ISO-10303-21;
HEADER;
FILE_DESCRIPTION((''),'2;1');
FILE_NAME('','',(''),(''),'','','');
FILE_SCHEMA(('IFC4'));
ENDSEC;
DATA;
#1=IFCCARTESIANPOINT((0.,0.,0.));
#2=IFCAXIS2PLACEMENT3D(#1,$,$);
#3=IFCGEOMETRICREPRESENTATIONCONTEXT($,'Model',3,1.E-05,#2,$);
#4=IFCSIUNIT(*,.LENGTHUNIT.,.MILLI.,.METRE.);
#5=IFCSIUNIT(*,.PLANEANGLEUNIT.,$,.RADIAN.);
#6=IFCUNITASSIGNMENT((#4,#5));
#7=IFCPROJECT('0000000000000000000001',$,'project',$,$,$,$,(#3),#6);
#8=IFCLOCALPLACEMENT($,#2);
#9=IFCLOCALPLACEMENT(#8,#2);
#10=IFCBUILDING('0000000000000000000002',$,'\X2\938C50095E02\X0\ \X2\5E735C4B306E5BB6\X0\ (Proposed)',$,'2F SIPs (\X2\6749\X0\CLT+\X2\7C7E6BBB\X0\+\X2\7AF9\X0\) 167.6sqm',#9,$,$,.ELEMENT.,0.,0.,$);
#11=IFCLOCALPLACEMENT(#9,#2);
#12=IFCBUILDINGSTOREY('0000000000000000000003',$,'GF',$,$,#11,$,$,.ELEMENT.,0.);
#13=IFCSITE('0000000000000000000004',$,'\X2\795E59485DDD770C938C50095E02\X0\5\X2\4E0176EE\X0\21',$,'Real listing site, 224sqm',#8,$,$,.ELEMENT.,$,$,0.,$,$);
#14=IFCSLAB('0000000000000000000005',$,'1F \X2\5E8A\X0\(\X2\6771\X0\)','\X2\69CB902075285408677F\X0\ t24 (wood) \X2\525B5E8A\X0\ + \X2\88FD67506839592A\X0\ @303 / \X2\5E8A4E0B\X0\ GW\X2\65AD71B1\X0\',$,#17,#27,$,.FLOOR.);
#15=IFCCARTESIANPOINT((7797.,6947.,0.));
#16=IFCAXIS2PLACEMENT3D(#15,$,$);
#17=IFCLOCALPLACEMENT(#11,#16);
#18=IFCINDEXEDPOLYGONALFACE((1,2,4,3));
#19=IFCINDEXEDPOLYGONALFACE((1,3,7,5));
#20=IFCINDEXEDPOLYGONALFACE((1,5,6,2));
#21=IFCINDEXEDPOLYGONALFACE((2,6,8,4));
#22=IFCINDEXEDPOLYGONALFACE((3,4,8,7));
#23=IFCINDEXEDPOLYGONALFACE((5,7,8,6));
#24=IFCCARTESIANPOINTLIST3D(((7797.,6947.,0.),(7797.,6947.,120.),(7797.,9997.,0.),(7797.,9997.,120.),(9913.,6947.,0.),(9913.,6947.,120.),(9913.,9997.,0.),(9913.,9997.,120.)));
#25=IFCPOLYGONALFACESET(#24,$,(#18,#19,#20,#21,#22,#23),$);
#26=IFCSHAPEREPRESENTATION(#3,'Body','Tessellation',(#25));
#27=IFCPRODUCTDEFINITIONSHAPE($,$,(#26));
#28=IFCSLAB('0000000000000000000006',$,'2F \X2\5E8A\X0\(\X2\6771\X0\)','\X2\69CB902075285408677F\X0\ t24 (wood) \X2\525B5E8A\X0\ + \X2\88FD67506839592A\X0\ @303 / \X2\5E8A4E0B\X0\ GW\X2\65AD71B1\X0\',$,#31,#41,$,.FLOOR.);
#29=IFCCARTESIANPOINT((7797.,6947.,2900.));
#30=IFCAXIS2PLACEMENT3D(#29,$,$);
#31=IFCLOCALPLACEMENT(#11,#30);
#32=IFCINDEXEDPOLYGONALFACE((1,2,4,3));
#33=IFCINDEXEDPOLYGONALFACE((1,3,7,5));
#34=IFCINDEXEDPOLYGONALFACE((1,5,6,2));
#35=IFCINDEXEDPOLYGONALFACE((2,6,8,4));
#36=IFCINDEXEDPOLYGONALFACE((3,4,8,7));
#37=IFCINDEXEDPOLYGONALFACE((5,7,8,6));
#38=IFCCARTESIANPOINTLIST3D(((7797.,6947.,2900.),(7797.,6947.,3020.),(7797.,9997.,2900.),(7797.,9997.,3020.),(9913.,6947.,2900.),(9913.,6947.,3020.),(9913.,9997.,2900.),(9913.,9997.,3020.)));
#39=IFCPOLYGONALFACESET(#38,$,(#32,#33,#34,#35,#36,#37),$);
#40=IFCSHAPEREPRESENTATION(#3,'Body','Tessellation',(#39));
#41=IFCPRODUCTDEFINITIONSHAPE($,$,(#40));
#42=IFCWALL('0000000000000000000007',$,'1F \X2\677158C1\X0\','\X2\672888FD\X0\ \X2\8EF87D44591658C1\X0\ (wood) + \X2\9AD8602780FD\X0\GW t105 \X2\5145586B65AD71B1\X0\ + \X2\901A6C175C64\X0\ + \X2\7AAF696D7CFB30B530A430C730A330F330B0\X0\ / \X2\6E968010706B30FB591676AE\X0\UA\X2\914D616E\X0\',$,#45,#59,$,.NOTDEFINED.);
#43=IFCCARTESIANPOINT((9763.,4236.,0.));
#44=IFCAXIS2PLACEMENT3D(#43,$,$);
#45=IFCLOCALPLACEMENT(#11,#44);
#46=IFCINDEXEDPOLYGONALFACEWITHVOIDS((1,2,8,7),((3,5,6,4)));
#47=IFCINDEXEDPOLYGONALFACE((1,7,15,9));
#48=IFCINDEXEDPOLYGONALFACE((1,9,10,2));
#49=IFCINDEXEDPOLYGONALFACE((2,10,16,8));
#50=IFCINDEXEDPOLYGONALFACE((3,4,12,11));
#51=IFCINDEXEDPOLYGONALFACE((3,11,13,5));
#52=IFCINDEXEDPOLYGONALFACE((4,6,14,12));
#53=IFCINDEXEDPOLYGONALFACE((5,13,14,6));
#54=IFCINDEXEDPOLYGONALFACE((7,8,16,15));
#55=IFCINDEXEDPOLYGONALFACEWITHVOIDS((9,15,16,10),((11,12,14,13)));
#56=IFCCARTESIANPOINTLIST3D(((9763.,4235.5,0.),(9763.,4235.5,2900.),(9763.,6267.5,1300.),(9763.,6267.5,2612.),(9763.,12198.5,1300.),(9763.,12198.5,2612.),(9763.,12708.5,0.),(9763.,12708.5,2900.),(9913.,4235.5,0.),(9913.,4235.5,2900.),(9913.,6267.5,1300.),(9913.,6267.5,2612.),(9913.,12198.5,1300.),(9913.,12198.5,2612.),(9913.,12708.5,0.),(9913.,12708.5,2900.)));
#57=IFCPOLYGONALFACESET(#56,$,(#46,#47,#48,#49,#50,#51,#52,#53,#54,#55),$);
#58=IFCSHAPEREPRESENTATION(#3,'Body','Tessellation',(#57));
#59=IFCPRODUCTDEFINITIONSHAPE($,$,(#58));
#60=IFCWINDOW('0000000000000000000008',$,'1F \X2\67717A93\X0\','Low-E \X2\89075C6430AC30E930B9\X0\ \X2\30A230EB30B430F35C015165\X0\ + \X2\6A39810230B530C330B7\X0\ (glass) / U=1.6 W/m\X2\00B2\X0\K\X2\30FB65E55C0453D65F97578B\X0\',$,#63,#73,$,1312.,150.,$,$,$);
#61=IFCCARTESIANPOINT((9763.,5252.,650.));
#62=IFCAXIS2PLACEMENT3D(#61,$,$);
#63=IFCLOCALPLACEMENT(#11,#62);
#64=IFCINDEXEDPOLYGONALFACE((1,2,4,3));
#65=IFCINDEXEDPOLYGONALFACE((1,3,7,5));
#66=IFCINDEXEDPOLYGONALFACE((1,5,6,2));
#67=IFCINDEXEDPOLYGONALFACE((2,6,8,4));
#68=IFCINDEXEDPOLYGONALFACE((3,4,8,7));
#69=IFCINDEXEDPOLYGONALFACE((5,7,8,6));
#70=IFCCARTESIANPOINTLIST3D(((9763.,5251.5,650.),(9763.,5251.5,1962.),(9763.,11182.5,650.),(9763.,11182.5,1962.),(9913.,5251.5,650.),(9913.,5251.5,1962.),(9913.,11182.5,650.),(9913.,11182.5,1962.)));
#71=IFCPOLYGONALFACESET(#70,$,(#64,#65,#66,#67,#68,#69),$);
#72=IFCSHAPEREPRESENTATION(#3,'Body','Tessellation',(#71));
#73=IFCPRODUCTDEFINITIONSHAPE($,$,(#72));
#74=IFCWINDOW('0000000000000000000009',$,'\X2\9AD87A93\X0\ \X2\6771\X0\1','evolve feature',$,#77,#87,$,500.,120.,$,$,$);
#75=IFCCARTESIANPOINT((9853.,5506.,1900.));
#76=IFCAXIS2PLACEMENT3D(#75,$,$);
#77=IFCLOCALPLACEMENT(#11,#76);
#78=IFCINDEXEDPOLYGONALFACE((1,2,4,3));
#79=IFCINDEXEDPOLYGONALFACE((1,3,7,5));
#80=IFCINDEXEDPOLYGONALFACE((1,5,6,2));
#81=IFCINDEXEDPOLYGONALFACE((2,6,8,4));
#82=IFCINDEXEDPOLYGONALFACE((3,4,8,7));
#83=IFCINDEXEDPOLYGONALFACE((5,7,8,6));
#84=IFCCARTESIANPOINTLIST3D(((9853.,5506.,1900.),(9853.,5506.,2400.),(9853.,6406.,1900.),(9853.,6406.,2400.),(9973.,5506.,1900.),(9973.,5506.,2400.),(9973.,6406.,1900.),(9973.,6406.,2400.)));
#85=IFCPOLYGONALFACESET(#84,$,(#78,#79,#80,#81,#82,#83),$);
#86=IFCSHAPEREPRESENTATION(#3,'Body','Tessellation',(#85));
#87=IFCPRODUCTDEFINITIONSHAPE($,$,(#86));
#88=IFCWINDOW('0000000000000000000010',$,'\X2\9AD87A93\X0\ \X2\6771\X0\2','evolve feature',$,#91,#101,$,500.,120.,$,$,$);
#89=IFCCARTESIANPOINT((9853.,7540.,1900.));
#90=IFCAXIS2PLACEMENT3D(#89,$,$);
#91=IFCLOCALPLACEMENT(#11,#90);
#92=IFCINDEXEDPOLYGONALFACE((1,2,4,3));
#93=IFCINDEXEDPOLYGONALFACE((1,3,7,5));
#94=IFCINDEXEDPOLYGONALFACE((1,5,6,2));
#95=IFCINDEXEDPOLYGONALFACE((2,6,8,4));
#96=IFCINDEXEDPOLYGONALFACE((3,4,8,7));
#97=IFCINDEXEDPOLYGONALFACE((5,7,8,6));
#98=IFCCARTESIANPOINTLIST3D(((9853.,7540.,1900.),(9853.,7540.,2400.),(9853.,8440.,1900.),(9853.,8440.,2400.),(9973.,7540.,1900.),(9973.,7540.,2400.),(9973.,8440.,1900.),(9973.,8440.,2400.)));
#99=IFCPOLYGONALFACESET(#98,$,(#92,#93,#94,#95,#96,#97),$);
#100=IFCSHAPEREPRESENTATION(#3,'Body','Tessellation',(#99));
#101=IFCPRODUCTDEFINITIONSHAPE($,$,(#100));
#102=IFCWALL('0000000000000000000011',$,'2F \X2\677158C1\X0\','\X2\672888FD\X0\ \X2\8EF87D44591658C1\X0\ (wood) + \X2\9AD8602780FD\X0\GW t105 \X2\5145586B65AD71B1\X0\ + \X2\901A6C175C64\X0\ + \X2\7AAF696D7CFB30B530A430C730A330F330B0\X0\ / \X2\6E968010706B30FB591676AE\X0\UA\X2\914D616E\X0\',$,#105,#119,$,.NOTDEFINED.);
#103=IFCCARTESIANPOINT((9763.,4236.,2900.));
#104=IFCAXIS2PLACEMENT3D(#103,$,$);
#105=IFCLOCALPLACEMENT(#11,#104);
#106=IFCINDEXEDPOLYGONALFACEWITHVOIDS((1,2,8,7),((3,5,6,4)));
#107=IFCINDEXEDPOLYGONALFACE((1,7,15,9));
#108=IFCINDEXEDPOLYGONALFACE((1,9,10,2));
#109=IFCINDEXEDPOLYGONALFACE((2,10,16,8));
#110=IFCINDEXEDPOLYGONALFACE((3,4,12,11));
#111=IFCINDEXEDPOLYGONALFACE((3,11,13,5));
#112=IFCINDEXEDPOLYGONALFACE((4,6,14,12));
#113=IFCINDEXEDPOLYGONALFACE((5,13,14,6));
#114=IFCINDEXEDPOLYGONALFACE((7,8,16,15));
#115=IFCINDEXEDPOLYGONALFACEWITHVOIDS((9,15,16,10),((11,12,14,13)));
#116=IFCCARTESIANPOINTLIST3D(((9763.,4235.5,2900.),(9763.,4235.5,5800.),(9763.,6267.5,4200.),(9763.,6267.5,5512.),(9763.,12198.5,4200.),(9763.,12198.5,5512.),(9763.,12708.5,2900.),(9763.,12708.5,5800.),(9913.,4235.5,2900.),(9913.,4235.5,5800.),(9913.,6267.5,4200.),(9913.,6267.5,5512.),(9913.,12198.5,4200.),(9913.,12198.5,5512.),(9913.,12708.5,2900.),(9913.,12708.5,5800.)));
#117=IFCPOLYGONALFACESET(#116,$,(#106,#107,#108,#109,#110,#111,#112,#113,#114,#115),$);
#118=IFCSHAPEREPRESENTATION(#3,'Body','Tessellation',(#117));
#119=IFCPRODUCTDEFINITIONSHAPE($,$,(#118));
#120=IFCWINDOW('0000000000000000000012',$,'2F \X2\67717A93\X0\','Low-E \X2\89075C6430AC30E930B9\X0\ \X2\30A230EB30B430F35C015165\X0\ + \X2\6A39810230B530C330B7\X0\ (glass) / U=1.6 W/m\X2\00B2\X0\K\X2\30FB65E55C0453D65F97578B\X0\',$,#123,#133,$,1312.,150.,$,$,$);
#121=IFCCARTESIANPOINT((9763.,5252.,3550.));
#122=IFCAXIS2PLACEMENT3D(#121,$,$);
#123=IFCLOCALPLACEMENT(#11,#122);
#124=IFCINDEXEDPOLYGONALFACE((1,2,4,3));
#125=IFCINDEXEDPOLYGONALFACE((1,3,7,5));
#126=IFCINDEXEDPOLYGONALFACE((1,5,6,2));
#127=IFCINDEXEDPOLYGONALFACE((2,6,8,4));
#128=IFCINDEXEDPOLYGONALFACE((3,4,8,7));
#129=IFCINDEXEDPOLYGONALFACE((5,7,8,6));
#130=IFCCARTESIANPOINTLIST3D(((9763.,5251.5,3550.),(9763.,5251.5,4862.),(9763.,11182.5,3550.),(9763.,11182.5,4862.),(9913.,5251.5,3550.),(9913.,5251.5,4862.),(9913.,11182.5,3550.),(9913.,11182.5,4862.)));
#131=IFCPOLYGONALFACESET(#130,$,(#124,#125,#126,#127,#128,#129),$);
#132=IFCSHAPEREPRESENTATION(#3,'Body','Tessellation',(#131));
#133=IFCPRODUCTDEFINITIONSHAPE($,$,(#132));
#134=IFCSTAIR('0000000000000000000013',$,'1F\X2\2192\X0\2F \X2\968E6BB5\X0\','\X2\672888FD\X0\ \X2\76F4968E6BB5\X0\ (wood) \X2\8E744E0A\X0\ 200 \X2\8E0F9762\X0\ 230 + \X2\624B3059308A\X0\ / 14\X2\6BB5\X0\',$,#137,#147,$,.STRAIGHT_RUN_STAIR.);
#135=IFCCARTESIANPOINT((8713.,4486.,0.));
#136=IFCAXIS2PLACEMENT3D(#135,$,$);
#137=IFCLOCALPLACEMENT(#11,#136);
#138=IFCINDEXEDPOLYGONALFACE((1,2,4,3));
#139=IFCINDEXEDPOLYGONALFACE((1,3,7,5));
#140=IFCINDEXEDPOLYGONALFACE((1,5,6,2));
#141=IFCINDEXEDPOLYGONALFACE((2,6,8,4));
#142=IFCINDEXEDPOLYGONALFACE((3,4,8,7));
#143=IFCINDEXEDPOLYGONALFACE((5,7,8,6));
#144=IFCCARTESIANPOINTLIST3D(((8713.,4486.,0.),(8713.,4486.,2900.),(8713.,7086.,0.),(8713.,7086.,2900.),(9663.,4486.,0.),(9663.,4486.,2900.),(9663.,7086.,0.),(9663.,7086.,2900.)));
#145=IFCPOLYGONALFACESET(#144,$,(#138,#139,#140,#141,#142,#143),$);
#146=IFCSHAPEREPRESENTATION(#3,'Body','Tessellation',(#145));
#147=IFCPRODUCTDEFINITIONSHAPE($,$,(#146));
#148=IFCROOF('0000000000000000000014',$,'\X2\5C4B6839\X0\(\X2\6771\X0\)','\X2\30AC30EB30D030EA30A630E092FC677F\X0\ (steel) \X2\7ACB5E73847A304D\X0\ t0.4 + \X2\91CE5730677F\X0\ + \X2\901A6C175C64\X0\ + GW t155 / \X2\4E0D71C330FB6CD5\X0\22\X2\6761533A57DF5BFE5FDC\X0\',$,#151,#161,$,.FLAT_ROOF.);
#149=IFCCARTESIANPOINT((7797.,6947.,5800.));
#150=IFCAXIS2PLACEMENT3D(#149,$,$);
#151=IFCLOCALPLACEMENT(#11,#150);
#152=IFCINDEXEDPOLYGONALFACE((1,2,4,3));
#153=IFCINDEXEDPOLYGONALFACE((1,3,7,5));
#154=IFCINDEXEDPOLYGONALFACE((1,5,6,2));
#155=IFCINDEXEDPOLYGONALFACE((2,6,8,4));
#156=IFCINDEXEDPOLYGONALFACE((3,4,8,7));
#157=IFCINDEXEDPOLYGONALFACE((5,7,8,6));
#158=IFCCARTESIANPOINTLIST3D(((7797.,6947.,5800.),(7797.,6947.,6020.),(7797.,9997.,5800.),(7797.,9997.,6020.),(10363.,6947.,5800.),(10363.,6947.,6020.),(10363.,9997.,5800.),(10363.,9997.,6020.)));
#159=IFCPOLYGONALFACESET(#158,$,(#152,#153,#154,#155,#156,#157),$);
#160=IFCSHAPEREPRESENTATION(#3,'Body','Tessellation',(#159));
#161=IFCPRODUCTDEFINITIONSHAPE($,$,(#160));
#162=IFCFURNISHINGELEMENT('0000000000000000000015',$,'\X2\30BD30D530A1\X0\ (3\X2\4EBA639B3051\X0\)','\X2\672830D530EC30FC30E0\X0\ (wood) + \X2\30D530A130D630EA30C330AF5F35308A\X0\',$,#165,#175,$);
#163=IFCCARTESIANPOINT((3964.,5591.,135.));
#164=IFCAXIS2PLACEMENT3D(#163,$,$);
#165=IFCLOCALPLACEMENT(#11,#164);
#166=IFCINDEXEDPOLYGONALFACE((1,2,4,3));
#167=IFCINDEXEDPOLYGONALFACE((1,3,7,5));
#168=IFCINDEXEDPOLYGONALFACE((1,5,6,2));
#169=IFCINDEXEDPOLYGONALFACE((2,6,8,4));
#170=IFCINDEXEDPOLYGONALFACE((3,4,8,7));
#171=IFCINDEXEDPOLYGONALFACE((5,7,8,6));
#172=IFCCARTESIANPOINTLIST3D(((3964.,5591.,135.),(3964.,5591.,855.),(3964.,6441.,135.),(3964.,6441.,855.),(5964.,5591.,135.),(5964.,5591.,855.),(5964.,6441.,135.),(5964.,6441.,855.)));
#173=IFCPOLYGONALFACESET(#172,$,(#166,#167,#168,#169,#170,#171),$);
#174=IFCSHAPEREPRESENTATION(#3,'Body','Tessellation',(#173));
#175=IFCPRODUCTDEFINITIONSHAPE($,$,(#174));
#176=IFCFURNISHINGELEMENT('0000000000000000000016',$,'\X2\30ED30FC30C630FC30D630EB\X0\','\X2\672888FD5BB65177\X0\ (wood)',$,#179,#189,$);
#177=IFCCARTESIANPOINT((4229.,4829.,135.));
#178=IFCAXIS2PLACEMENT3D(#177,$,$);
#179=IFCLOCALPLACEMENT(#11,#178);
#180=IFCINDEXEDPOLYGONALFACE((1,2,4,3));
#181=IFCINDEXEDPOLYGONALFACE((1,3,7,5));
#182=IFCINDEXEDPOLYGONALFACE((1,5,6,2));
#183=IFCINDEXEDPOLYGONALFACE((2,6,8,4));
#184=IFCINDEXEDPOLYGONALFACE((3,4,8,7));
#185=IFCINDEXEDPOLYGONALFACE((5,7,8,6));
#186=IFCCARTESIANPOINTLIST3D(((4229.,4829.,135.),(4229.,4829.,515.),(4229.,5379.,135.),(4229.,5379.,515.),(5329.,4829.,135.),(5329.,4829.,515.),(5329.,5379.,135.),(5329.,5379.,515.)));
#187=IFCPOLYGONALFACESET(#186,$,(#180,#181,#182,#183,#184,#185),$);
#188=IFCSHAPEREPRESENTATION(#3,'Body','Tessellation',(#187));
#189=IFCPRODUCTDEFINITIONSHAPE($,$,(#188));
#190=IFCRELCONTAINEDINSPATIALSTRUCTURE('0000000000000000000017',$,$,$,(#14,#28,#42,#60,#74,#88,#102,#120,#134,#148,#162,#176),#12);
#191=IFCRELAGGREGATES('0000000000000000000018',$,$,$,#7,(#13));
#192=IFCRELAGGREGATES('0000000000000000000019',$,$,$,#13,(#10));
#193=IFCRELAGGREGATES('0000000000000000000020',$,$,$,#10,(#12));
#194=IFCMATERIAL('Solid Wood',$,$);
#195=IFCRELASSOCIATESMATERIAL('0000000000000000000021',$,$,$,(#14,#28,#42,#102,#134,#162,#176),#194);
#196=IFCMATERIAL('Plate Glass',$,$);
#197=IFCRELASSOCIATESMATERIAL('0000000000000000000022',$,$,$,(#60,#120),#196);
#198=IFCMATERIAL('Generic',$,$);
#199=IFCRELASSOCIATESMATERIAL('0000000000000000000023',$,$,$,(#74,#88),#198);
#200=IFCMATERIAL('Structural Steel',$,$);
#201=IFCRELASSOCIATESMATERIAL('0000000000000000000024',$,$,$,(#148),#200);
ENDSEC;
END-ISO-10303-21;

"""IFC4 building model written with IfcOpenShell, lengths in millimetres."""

from ifc_helpers import new_model, si_unit, frame, frame_2d, origin, place, context, project, spatial, rectangle, extrude, material, element, fill, save


model = new_model("IFC4")

# Units and contexts
model_context = context("Model", 3, precision=1e-05, world=origin())
ifc_project = project(units=[si_unit("LENGTHUNIT", "METRE", prefix="MILLI"), si_unit("PLANEANGLEUNIT", "RADIAN")], contexts=[model_context])

# Site, building, storey
site_placement = place(None, origin())
site = spatial("IfcSite", under=ifc_project, at=site_placement, Name="神奈川県鎌倉市5丁目21", ObjectType="Real listing site, 224sqm", CompositionType="ELEMENT", RefElevation=0.0)
building_placement = place(site_placement, origin())
building = spatial("IfcBuilding", under=site, at=building_placement, Name="鎌倉市 平屋の家 (Proposed)", ObjectType="2F SIPs (杉CLT+籾殻+竹) 167.6sqm", CompositionType="ELEMENT", ElevationOfRefHeight=0.0, ElevationOfTerrain=0.0)
storey_placement = place(building_placement, origin())
storey = spatial("IfcBuildingStorey", under=building, at=storey_placement, Name="GF", CompositionType="ELEMENT", Elevation=0.0)

# Slabs
ifc_material_1 = material(Name="Solid Wood")
slab_1_placement = place(storey_placement, frame((7797.0, 6947.0, 0.0)))
element("IfcSlab", 1, at=slab_1_placement, inside=storey, material=ifc_material_1, Name="1F 床(東)", Description="構造用合板 t24 (wood) 剛床 + 製材根太 @303 / 床下 GW断熱", PredefinedType="FLOOR", context=model_context, shape_type="SweptSolid", body=[
    extrude(rectangle(XDim=2116.0, YDim=3050.0, at=frame_2d((1058.0, 1525.0))), frame((7797.0, 6947.0, 0.0)), (0.0, 0.0, 1.0), 120.0),
])
slab_2_placement = place(storey_placement, frame((7797.0, 6947.0, 2900.0)))
element("IfcSlab", 2, at=slab_2_placement, inside=storey, material=ifc_material_1, Name="2F 床(東)", Description="構造用合板 t24 (wood) 剛床 + 製材根太 @303 / 床下 GW断熱", PredefinedType="FLOOR", context=model_context, shape_type="SweptSolid", body=[
    extrude(rectangle(XDim=2116.0, YDim=3050.0, at=frame_2d((1058.0, 1525.0))), frame((7797.0, 6947.0, 2900.0)), (0.0, 0.0, 1.0), 120.0),
])

# Wall, openings, windows
wall_1_placement = place(storey_placement, frame((9763.0, 4236.0, 0.0)))
wall_1 = element("IfcWall", 3, at=wall_1_placement, inside=storey, material=ifc_material_1, Name="1F 東壁", Description="木製 軸組外壁 (wood) + 高性能GW t105 充填断熱 + 通気層 + 窯業系サイディング / 準耐火・外皮UA配慮", PredefinedType="NOTDEFINED", context=model_context, shape_type="SweptSolid", body=[
    extrude(rectangle(XDim=150.0, YDim=8473.0, at=frame_2d((75.0, 4236.0))), frame((9763.0, 4236.0, 0.0)), (0.0, 0.0, 1.0), 2900.0),
])
opening_1_placement = place(storey_placement, frame((9763.0, 5252.0, 650.0)))
opening_1 = element("IfcOpeningElement", 4, at=opening_1_placement, cuts=wall_1, PredefinedType="NOTDEFINED", context=model_context, shape_type="SweptSolid", body=[
    extrude(rectangle(XDim=150.0, YDim=5931.0, at=frame_2d((75.0, 2965.0))), frame((9763.0, 5252.0, 650.0)), (0.0, 0.0, 1.0), 1312.0),
])
opening_2_placement = place(storey_placement, frame((9853.0, 5506.0, 1900.0)))
opening_2 = element("IfcOpeningElement", 5, at=opening_2_placement, cuts=wall_1, PredefinedType="NOTDEFINED", context=model_context, shape_type="SweptSolid", body=[
    extrude(rectangle(XDim=120.0, YDim=900.0, at=frame_2d((60.0, 450.0))), frame((9853.0, 5506.0, 1900.0)), (0.0, 0.0, 1.0), 500.0),
])
opening_3_placement = place(storey_placement, frame((9853.0, 7540.0, 1900.0)))
opening_3 = element("IfcOpeningElement", 6, at=opening_3_placement, cuts=wall_1, PredefinedType="NOTDEFINED", context=model_context, shape_type="SweptSolid", body=[
    extrude(rectangle(XDim=120.0, YDim=900.0, at=frame_2d((60.0, 450.0))), frame((9853.0, 7540.0, 1900.0)), (0.0, 0.0, 1.0), 500.0),
])
ifc_material_2 = material(Name="Plate Glass")
window_1_placement = place(storey_placement, frame((9763.0, 5252.0, 650.0)))
window_1 = element("IfcWindow", 7, at=window_1_placement, inside=storey, material=ifc_material_2, Name="1F 東窓", Description="Low-E 複層ガラス アルゴン封入 + 樹脂サッシ (glass) / U=1.6 W/m²K・日射取得型", OverallHeight=1312.0, OverallWidth=150.0, context=model_context, shape_type="SweptSolid", body=[
    extrude(rectangle(XDim=150.0, YDim=5931.0, at=frame_2d((75.0, 2965.0))), frame((9763.0, 5252.0, 650.0)), (0.0, 0.0, 1.0), 1312.0),
])
fill(opening_1, window_1)
ifc_material_3 = material(Name="Generic")
window_2_placement = place(storey_placement, frame((9853.0, 5506.0, 1900.0)))
window_2 = element("IfcWindow", 8, at=window_2_placement, inside=storey, material=ifc_material_3, Name="高窓 東1", Description="evolve feature", OverallHeight=500.0, OverallWidth=120.0, context=model_context, shape_type="SweptSolid", body=[
    extrude(rectangle(XDim=120.0, YDim=900.0, at=frame_2d((60.0, 450.0))), frame((9853.0, 5506.0, 1900.0)), (0.0, 0.0, 1.0), 500.0),
])
fill(opening_2, window_2)
window_3_placement = place(storey_placement, frame((9853.0, 7540.0, 1900.0)))
window_3 = element("IfcWindow", 9, at=window_3_placement, inside=storey, material=ifc_material_3, Name="高窓 東2", Description="evolve feature", OverallHeight=500.0, OverallWidth=120.0, context=model_context, shape_type="SweptSolid", body=[
    extrude(rectangle(XDim=120.0, YDim=900.0, at=frame_2d((60.0, 450.0))), frame((9853.0, 7540.0, 1900.0)), (0.0, 0.0, 1.0), 500.0),
])
fill(opening_3, window_3)

# Wall, opening, window
wall_2_placement = place(storey_placement, frame((9763.0, 4236.0, 2900.0)))
wall_2 = element("IfcWall", 10, at=wall_2_placement, inside=storey, material=ifc_material_1, Name="2F 東壁", Description="木製 軸組外壁 (wood) + 高性能GW t105 充填断熱 + 通気層 + 窯業系サイディング / 準耐火・外皮UA配慮", PredefinedType="NOTDEFINED", context=model_context, shape_type="SweptSolid", body=[
    extrude(rectangle(XDim=150.0, YDim=8473.0, at=frame_2d((75.0, 4236.0))), frame((9763.0, 4236.0, 2900.0)), (0.0, 0.0, 1.0), 2900.0),
])
opening_4_placement = place(storey_placement, frame((9763.0, 5252.0, 3550.0)))
opening_4 = element("IfcOpeningElement", 11, at=opening_4_placement, cuts=wall_2, PredefinedType="NOTDEFINED", context=model_context, shape_type="SweptSolid", body=[
    extrude(rectangle(XDim=150.0, YDim=5931.0, at=frame_2d((75.0, 2965.0))), frame((9763.0, 5252.0, 3550.0)), (0.0, 0.0, 1.0), 1312.0),
])
window_4_placement = place(storey_placement, frame((9763.0, 5252.0, 3550.0)))
window_4 = element("IfcWindow", 12, at=window_4_placement, inside=storey, material=ifc_material_2, Name="2F 東窓", Description="Low-E 複層ガラス アルゴン封入 + 樹脂サッシ (glass) / U=1.6 W/m²K・日射取得型", OverallHeight=1312.0, OverallWidth=150.0, context=model_context, shape_type="SweptSolid", body=[
    extrude(rectangle(XDim=150.0, YDim=5931.0, at=frame_2d((75.0, 2965.0))), frame((9763.0, 5252.0, 3550.0)), (0.0, 0.0, 1.0), 1312.0),
])
fill(opening_4, window_4)

# Stair
stair_placement = place(storey_placement, frame((8713.0, 4486.0, 0.0)))
element("IfcStair", 13, at=stair_placement, inside=storey, material=ifc_material_1, Name="1F→2F 階段", Description="木製 直階段 (wood) 蹴上 200 踏面 230 + 手すり / 14段", PredefinedType="STRAIGHT_RUN_STAIR", context=model_context, shape_type="SweptSolid", body=[
    extrude(rectangle(XDim=950.0, YDim=2600.0, at=frame_2d((475.0, 1300.0))), frame((8713.0, 4486.0, 0.0)), (0.0, 0.0, 1.0), 2900.0),
])

# Roof
ifc_material_4 = material(Name="Structural Steel")
roof_placement = place(storey_placement, frame((7797.0, 6947.0, 5800.0)))
element("IfcRoof", 14, at=roof_placement, inside=storey, material=ifc_material_4, Name="屋根(東)", Description="ガルバリウム鋼板 (steel) 立平葺き t0.4 + 野地板 + 通気層 + GW t155 / 不燃・法22条区域対応", PredefinedType="FLAT_ROOF", context=model_context, shape_type="SweptSolid", body=[
    extrude(rectangle(XDim=2566.0, YDim=3050.0, at=frame_2d((1283.0, 1525.0))), frame((7797.0, 6947.0, 5800.0)), (0.0, 0.0, 1.0), 220.0),
])

# Furnishing elements
furnishing_1_placement = place(storey_placement, frame((3964.0, 5591.0, 135.0)))
element("IfcFurnishingElement", 15, at=furnishing_1_placement, inside=storey, material=ifc_material_1, Name="ソファ (3人掛け)", Description="木フレーム (wood) + ファブリック張り", context=model_context, shape_type="SweptSolid", body=[
    extrude(rectangle(XDim=2000.0, YDim=850.0, at=frame_2d((1000.0, 425.0))), frame((3964.0, 5591.0, 135.0)), (0.0, 0.0, 1.0), 720.0),
])
furnishing_2_placement = place(storey_placement, frame((4229.0, 4829.0, 135.0)))
element("IfcFurnishingElement", 16, at=furnishing_2_placement, inside=storey, material=ifc_material_1, Name="ローテーブル", Description="木製家具 (wood)", context=model_context, shape_type="SweptSolid", body=[
    extrude(rectangle(XDim=1100.0, YDim=550.0, at=frame_2d((550.0, 275.0))), frame((4229.0, 4829.0, 135.0)), (0.0, 0.0, 1.0), 380.0),
])

save(model, "model.ifc")
